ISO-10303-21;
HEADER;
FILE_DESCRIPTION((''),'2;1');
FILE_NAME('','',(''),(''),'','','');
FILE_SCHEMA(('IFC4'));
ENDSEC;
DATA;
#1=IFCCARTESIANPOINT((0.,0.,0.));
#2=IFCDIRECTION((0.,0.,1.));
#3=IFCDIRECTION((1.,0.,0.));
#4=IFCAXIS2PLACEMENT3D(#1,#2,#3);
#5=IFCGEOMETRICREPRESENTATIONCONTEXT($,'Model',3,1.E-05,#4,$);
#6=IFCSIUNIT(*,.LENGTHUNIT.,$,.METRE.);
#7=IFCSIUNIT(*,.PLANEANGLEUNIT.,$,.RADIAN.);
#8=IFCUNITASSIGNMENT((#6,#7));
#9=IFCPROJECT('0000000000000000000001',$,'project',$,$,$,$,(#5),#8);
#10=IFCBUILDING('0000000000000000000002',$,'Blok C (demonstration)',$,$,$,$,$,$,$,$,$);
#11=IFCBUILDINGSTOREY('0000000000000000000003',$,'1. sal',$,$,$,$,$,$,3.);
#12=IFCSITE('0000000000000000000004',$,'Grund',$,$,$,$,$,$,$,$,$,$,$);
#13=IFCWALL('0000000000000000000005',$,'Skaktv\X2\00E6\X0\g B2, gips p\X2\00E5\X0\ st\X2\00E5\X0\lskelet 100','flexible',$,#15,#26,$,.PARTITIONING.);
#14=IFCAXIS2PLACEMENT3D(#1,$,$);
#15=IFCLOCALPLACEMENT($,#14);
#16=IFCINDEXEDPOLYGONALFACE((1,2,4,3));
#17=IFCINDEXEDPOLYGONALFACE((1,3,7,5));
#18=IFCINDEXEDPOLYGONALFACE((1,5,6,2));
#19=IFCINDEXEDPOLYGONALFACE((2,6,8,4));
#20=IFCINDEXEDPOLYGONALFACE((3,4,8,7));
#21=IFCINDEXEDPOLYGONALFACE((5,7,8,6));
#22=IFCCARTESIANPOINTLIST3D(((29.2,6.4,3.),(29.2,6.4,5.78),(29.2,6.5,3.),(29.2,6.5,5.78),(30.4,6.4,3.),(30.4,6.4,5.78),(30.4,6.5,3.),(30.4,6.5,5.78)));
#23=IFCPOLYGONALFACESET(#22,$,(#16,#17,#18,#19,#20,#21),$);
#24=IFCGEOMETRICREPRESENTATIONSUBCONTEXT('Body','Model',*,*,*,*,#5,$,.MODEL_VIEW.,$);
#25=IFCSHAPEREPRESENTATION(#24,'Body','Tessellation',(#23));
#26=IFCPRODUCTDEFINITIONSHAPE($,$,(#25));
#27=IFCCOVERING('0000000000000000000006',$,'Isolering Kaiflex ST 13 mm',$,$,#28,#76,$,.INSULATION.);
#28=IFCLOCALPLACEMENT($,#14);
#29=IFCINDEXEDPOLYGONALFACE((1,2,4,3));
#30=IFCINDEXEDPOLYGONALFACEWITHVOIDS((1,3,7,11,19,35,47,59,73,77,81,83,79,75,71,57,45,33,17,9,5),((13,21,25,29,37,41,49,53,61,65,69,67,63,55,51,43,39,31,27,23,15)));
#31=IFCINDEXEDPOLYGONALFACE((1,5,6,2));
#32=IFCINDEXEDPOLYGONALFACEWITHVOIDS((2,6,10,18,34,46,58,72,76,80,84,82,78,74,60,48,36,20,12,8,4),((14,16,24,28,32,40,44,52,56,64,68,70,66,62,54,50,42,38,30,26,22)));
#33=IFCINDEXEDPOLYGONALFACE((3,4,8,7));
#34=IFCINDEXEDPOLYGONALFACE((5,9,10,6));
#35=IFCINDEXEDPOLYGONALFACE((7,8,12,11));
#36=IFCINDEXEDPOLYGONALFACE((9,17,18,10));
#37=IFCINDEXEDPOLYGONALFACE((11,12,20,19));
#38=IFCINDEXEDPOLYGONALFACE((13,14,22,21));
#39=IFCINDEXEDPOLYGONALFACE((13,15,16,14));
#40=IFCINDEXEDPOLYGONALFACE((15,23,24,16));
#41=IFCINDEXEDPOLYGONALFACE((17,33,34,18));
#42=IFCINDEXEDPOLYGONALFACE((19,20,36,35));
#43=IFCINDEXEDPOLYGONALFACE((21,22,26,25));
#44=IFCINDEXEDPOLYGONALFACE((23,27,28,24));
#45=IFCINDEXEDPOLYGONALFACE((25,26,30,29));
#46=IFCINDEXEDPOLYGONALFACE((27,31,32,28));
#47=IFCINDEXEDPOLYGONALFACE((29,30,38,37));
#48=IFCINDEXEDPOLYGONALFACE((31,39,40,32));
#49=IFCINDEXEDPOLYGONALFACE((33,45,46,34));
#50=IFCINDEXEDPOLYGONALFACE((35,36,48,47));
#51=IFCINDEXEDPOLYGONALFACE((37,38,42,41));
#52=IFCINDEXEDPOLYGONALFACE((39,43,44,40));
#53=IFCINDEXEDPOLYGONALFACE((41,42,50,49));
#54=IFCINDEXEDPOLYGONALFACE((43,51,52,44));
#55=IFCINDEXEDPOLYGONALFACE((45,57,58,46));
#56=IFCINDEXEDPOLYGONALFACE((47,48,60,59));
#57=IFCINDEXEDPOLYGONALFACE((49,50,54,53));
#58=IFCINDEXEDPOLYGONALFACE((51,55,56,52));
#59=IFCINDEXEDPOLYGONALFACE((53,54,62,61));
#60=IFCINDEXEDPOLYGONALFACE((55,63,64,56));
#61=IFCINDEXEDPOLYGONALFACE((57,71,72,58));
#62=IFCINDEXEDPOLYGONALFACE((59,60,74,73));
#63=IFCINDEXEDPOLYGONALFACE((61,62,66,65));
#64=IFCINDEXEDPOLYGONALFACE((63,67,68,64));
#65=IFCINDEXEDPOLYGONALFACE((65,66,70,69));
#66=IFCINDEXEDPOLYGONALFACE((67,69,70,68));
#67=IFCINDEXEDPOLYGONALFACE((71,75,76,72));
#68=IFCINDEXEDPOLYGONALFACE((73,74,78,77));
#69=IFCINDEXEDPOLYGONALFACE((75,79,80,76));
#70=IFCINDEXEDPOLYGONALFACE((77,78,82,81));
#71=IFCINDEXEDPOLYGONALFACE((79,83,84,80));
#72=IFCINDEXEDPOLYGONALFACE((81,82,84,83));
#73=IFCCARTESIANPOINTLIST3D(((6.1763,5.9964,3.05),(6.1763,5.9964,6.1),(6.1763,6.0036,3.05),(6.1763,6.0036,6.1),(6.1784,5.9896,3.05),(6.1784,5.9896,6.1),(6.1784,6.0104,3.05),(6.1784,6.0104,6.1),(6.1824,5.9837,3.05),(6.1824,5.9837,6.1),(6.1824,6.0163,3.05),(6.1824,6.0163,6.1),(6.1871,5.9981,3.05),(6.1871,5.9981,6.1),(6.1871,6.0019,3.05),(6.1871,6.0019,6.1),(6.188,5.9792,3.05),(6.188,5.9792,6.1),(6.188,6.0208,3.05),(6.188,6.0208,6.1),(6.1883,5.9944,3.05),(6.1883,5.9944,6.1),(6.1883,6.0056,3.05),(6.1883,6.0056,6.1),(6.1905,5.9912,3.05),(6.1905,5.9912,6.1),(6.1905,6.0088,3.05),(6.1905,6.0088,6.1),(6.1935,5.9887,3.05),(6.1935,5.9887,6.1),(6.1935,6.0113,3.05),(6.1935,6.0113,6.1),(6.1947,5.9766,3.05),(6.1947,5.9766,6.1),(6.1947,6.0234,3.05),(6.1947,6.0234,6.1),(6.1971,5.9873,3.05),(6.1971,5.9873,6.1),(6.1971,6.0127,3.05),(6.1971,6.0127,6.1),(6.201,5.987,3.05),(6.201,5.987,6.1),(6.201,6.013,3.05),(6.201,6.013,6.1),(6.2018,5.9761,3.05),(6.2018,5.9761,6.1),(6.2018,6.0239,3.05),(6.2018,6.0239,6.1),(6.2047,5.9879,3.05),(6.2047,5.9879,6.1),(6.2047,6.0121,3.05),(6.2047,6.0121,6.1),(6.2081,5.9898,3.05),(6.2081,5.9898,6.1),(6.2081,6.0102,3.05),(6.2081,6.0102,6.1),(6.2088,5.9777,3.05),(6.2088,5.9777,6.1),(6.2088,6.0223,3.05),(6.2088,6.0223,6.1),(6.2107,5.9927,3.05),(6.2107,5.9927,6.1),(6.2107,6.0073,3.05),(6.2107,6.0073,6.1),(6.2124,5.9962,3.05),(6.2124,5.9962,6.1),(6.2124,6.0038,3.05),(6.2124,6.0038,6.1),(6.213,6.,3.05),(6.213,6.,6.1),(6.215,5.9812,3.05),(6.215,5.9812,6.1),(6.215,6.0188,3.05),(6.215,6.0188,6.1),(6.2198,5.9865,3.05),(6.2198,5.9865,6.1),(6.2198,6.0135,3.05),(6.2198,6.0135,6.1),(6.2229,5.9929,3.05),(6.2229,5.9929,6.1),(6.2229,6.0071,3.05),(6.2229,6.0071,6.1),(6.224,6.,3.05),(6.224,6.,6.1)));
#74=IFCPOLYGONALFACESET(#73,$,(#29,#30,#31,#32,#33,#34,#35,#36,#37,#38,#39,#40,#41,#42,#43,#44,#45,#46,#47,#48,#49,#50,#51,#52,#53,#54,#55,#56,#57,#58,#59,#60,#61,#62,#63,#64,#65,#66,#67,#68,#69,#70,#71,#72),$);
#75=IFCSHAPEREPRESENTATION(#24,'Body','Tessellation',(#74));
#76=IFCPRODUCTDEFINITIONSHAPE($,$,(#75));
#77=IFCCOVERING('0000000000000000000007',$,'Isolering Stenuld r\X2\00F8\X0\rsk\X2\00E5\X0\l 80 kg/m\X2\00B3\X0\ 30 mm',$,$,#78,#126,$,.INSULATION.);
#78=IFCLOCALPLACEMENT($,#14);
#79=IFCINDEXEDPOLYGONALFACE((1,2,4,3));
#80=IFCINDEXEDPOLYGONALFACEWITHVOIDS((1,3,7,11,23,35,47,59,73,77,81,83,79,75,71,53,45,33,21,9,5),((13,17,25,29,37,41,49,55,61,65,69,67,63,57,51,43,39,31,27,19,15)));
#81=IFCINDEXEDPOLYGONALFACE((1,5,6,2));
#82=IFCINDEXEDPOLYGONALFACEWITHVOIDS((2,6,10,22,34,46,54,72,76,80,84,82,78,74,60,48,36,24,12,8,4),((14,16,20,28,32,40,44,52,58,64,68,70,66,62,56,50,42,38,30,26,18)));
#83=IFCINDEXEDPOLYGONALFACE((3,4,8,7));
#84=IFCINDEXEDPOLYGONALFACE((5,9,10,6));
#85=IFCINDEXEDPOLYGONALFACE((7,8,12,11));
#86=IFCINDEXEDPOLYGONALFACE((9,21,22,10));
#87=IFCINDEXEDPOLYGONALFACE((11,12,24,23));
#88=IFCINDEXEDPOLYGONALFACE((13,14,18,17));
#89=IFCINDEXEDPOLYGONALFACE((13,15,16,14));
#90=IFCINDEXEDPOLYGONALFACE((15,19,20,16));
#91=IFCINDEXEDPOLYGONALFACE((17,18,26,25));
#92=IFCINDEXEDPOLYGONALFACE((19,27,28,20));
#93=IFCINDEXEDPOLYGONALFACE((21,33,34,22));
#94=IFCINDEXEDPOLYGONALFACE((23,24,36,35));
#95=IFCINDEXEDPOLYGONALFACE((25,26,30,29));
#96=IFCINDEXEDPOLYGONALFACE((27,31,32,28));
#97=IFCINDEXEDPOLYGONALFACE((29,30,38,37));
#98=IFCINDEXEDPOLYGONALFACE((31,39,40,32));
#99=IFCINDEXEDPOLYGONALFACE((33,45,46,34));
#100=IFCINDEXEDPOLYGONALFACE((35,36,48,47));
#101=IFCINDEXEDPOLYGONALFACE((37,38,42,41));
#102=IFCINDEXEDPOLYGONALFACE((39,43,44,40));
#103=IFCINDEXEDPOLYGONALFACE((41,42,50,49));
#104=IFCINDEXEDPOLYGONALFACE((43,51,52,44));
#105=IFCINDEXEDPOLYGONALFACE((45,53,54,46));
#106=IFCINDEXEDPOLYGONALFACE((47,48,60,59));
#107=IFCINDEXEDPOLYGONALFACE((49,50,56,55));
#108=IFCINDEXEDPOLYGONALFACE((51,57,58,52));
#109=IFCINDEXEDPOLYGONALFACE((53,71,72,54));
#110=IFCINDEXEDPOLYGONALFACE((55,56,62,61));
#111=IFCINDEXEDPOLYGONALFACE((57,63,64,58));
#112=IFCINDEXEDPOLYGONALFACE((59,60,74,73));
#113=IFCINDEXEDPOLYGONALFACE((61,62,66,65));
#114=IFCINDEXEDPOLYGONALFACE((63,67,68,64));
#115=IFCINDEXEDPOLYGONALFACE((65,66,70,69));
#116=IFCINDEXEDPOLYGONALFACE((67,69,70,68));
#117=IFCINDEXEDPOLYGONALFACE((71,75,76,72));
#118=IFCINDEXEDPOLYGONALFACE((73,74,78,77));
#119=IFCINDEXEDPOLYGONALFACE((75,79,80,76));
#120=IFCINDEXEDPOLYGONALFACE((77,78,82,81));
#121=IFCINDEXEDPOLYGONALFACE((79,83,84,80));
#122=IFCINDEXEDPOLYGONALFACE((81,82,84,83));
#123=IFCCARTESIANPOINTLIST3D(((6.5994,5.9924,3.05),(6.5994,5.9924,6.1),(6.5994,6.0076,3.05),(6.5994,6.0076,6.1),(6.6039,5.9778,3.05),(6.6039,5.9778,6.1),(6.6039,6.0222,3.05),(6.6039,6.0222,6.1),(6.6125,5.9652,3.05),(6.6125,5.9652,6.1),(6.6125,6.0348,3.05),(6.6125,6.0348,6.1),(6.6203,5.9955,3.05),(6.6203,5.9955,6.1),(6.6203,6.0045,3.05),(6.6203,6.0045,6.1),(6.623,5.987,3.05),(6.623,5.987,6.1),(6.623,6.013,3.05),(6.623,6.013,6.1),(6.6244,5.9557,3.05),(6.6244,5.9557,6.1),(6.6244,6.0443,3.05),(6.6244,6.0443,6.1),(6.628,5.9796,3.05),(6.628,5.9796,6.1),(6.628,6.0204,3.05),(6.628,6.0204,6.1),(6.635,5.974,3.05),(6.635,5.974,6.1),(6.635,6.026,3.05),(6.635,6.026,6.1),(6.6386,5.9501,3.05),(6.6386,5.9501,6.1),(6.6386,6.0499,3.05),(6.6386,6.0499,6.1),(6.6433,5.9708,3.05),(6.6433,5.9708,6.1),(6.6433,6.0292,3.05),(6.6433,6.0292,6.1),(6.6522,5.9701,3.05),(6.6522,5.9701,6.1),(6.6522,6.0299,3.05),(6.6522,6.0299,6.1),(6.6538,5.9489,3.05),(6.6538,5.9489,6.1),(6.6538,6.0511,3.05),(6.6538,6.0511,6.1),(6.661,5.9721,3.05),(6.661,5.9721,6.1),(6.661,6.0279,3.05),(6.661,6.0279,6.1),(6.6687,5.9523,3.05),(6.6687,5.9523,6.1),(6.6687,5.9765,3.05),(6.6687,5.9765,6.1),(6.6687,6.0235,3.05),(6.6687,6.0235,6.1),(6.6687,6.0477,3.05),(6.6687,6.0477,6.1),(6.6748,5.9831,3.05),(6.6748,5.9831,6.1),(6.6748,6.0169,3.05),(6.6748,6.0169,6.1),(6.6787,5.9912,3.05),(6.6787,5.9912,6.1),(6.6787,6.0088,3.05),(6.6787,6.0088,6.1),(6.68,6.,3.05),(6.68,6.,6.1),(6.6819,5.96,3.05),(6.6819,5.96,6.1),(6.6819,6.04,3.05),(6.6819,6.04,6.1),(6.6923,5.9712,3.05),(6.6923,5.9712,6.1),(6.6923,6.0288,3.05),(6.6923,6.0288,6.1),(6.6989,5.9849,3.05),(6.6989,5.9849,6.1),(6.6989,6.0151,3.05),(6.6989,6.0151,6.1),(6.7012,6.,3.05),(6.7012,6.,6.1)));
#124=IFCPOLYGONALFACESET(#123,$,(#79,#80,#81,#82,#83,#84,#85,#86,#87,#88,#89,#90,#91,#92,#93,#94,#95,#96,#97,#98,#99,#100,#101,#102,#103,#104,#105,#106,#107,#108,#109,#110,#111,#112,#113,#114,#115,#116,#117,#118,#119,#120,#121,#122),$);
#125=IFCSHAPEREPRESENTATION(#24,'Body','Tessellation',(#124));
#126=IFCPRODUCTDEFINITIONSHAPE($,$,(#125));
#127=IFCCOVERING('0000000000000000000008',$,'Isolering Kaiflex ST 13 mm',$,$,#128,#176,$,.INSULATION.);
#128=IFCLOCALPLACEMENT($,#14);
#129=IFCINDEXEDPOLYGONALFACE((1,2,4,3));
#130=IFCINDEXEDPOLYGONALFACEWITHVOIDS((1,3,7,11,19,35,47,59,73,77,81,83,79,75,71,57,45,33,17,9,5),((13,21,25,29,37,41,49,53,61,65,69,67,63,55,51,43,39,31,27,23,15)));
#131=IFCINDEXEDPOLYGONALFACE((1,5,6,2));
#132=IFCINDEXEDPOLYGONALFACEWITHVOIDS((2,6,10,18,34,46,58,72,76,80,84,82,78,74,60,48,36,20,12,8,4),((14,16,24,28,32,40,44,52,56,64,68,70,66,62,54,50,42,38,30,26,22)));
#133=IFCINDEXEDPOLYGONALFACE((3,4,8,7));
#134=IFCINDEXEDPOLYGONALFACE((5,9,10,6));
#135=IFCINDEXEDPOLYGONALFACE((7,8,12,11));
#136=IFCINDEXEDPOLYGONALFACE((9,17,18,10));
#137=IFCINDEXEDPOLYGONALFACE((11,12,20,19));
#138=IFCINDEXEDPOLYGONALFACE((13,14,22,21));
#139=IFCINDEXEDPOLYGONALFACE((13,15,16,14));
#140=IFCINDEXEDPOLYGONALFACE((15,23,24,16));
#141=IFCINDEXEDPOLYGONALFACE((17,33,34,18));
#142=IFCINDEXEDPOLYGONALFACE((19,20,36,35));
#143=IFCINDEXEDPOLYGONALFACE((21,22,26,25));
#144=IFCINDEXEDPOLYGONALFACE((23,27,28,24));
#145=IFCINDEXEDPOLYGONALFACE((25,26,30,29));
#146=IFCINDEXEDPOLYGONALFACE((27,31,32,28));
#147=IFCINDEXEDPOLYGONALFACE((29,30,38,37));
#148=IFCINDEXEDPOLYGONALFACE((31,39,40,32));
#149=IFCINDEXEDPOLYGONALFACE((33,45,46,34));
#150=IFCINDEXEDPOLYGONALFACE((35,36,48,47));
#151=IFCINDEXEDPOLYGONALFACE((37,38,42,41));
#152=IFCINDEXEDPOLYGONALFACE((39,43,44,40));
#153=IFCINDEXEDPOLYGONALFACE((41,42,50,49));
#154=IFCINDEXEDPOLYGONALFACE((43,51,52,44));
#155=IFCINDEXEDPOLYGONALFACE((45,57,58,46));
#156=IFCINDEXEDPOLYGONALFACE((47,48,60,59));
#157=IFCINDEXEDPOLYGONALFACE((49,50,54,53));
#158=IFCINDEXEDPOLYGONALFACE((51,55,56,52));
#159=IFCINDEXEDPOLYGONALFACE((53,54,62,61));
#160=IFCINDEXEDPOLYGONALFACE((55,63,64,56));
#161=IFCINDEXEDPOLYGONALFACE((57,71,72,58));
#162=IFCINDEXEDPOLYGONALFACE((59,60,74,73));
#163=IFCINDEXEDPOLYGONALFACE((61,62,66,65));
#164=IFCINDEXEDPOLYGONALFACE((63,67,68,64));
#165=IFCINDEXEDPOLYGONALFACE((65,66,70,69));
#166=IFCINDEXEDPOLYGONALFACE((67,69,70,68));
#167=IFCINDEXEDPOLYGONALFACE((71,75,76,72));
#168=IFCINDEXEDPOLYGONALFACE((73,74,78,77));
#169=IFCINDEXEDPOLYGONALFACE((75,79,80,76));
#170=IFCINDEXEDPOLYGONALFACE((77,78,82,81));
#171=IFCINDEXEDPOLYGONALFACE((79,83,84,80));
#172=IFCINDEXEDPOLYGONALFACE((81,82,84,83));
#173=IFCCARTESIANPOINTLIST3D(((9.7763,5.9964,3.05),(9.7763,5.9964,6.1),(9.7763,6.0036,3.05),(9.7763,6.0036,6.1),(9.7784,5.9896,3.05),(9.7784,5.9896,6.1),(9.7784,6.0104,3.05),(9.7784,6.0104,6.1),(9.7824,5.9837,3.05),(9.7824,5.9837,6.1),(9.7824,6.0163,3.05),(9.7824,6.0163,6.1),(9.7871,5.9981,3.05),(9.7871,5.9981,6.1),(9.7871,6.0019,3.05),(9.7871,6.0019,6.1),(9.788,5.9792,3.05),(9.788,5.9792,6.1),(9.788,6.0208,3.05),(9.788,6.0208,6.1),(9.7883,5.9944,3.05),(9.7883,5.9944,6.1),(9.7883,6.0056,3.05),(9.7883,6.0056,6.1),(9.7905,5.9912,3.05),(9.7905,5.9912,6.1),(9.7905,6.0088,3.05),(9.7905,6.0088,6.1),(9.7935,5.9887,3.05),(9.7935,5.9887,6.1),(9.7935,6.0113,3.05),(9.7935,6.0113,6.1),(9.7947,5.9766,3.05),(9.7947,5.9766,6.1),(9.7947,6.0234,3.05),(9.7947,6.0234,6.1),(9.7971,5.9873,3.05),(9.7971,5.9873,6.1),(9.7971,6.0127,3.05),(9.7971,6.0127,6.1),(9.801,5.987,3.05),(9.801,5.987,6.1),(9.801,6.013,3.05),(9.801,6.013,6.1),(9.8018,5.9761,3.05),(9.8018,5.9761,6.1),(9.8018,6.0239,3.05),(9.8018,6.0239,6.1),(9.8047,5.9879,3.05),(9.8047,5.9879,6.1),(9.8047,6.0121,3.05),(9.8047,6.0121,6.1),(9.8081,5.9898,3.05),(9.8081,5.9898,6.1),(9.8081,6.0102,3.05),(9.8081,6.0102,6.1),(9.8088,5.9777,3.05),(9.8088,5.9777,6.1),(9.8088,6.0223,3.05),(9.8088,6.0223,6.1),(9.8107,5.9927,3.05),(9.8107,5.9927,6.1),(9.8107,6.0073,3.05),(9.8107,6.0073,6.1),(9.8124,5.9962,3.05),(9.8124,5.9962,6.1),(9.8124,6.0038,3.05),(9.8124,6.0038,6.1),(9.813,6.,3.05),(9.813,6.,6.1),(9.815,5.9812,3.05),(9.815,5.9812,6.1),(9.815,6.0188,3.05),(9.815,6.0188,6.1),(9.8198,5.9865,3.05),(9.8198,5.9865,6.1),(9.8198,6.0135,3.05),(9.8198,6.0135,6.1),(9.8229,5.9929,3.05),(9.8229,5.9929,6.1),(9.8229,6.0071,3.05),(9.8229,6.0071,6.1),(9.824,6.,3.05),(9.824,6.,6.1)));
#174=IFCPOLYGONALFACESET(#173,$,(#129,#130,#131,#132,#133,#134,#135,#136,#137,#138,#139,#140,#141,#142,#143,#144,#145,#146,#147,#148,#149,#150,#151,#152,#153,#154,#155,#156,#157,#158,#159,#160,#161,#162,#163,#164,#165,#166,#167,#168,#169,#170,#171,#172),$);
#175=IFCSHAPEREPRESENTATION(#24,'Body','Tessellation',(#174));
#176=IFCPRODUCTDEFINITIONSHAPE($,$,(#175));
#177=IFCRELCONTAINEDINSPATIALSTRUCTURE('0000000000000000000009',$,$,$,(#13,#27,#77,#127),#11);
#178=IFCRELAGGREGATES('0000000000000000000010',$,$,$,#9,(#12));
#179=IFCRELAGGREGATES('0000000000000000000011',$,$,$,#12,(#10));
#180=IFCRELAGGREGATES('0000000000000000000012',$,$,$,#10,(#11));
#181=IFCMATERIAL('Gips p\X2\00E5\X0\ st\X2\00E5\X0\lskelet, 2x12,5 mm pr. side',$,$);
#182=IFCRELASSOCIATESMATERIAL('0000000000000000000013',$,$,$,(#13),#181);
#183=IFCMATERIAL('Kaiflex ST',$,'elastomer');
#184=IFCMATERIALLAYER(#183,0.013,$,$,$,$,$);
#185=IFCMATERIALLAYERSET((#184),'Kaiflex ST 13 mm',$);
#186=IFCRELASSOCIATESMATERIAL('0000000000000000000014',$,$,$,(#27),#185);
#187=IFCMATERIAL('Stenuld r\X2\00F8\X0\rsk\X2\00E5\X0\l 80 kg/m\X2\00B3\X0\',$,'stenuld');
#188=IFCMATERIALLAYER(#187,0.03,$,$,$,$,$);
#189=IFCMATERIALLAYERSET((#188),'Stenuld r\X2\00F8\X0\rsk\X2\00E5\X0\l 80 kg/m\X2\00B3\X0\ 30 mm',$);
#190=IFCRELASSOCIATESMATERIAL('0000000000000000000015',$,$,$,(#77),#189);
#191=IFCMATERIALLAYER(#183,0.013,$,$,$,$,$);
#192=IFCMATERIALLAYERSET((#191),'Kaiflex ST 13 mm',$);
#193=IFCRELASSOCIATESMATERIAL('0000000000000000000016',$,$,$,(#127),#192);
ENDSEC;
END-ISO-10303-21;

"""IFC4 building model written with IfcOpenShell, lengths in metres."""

from ifc_helpers import new_model, si_unit, frame, origin_with_axes, place, context, subcontext, project, spatial, polyline, hollow_circle, outline, extrude, material, layer, layer_set, element, save


model = new_model("IFC4")

# Units and contexts
model_context = context("Model", 3, precision=1e-05, world=origin_with_axes())
body_context = subcontext(model_context, "Body", "Model", "MODEL_VIEW")
ifc_project = project(units=[si_unit("LENGTHUNIT", "METRE"), si_unit("PLANEANGLEUNIT", "RADIAN")], contexts=[model_context])

# Site, building, storey
site = spatial("IfcSite", under=ifc_project, Name="Grund")
building = spatial("IfcBuilding", under=site, Name="Blok C (demonstration)")
storey = spatial("IfcBuildingStorey", under=building, Name="1. sal", Elevation=3.0)

# Shared definitions
ifc_material_1 = material(Name="Gips på stålskelet, 2x12,5 mm pr. side")

# Wall
wall_1_placement = place(None, origin_with_axes())
element("IfcWall", 1, at=wall_1_placement, inside=storey, material=ifc_material_1, Name="Skaktvæg B2, gips på stålskelet 100", Description="flexible", PredefinedType="PARTITIONING", context=body_context, shape_type="SweptSolid", body=[
    extrude(outline(polyline([(29.2, 6.4), (30.4, 6.4), (30.4, 6.5), (29.2, 6.5), (29.2, 6.4)])), frame((0.0, 0.0, 3.0)), (0.0, 0.0, 1.0), 2.78),
])

# Coverings
ifc_material_2 = material(Name="Kaiflex ST", Category="elastomer")
ifc_layer_1 = layer(ifc_material_2, 0.013)
ifc_layer_set_1 = layer_set([ifc_layer_1], Name="Kaiflex ST 13 mm")
covering_1_placement = place(None, origin_with_axes())
element("IfcCovering", 2, at=covering_1_placement, inside=storey, material=ifc_layer_set_1, Name="Isolering Kaiflex ST 13 mm", PredefinedType="INSULATION", context=body_context, shape_type="SweptSolid", body=[
    extrude(hollow_circle(Radius=0.024, WallThickness=0.011), frame((6.2, 6.0, 3.05), z_axis=(0.0, 0.0, 1.0), x_axis=(1.0, 0.0, 0.0)), (0.0, 0.0, 1.0), 3.05),
])
ifc_material_3 = material(Name="Stenuld rørskål 80 kg/m³", Category="stenuld")
ifc_layer_2 = layer(ifc_material_3, 0.03)
ifc_layer_set_2 = layer_set([ifc_layer_2], Name="Stenuld rørskål 80 kg/m³ 30 mm")
covering_2_placement = place(None, origin_with_axes())
element("IfcCovering", 3, at=covering_2_placement, inside=storey, material=ifc_layer_set_2, Name="Isolering Stenuld rørskål 80 kg/m³ 30 mm", PredefinedType="INSULATION", context=body_context, shape_type="SweptSolid", body=[
    extrude(hollow_circle(Radius=0.0512, WallThickness=0.0212), frame((6.65, 6.0, 3.05), z_axis=(0.0, 0.0, 1.0), x_axis=(1.0, 0.0, 0.0)), (0.0, 0.0, 1.0), 3.05),
])
ifc_layer_3 = layer(ifc_material_2, 0.013)
ifc_layer_set_3 = layer_set([ifc_layer_3], Name="Kaiflex ST 13 mm")
covering_3_placement = place(None, origin_with_axes())
element("IfcCovering", 4, at=covering_3_placement, inside=storey, material=ifc_layer_set_3, Name="Isolering Kaiflex ST 13 mm", PredefinedType="INSULATION", context=body_context, shape_type="SweptSolid", body=[
    extrude(hollow_circle(Radius=0.024, WallThickness=0.011), frame((9.8, 6.0, 3.05), z_axis=(0.0, 0.0, 1.0), x_axis=(1.0, 0.0, 0.0)), (0.0, 0.0, 1.0), 3.05),
])

save(model, "model.ifc")
